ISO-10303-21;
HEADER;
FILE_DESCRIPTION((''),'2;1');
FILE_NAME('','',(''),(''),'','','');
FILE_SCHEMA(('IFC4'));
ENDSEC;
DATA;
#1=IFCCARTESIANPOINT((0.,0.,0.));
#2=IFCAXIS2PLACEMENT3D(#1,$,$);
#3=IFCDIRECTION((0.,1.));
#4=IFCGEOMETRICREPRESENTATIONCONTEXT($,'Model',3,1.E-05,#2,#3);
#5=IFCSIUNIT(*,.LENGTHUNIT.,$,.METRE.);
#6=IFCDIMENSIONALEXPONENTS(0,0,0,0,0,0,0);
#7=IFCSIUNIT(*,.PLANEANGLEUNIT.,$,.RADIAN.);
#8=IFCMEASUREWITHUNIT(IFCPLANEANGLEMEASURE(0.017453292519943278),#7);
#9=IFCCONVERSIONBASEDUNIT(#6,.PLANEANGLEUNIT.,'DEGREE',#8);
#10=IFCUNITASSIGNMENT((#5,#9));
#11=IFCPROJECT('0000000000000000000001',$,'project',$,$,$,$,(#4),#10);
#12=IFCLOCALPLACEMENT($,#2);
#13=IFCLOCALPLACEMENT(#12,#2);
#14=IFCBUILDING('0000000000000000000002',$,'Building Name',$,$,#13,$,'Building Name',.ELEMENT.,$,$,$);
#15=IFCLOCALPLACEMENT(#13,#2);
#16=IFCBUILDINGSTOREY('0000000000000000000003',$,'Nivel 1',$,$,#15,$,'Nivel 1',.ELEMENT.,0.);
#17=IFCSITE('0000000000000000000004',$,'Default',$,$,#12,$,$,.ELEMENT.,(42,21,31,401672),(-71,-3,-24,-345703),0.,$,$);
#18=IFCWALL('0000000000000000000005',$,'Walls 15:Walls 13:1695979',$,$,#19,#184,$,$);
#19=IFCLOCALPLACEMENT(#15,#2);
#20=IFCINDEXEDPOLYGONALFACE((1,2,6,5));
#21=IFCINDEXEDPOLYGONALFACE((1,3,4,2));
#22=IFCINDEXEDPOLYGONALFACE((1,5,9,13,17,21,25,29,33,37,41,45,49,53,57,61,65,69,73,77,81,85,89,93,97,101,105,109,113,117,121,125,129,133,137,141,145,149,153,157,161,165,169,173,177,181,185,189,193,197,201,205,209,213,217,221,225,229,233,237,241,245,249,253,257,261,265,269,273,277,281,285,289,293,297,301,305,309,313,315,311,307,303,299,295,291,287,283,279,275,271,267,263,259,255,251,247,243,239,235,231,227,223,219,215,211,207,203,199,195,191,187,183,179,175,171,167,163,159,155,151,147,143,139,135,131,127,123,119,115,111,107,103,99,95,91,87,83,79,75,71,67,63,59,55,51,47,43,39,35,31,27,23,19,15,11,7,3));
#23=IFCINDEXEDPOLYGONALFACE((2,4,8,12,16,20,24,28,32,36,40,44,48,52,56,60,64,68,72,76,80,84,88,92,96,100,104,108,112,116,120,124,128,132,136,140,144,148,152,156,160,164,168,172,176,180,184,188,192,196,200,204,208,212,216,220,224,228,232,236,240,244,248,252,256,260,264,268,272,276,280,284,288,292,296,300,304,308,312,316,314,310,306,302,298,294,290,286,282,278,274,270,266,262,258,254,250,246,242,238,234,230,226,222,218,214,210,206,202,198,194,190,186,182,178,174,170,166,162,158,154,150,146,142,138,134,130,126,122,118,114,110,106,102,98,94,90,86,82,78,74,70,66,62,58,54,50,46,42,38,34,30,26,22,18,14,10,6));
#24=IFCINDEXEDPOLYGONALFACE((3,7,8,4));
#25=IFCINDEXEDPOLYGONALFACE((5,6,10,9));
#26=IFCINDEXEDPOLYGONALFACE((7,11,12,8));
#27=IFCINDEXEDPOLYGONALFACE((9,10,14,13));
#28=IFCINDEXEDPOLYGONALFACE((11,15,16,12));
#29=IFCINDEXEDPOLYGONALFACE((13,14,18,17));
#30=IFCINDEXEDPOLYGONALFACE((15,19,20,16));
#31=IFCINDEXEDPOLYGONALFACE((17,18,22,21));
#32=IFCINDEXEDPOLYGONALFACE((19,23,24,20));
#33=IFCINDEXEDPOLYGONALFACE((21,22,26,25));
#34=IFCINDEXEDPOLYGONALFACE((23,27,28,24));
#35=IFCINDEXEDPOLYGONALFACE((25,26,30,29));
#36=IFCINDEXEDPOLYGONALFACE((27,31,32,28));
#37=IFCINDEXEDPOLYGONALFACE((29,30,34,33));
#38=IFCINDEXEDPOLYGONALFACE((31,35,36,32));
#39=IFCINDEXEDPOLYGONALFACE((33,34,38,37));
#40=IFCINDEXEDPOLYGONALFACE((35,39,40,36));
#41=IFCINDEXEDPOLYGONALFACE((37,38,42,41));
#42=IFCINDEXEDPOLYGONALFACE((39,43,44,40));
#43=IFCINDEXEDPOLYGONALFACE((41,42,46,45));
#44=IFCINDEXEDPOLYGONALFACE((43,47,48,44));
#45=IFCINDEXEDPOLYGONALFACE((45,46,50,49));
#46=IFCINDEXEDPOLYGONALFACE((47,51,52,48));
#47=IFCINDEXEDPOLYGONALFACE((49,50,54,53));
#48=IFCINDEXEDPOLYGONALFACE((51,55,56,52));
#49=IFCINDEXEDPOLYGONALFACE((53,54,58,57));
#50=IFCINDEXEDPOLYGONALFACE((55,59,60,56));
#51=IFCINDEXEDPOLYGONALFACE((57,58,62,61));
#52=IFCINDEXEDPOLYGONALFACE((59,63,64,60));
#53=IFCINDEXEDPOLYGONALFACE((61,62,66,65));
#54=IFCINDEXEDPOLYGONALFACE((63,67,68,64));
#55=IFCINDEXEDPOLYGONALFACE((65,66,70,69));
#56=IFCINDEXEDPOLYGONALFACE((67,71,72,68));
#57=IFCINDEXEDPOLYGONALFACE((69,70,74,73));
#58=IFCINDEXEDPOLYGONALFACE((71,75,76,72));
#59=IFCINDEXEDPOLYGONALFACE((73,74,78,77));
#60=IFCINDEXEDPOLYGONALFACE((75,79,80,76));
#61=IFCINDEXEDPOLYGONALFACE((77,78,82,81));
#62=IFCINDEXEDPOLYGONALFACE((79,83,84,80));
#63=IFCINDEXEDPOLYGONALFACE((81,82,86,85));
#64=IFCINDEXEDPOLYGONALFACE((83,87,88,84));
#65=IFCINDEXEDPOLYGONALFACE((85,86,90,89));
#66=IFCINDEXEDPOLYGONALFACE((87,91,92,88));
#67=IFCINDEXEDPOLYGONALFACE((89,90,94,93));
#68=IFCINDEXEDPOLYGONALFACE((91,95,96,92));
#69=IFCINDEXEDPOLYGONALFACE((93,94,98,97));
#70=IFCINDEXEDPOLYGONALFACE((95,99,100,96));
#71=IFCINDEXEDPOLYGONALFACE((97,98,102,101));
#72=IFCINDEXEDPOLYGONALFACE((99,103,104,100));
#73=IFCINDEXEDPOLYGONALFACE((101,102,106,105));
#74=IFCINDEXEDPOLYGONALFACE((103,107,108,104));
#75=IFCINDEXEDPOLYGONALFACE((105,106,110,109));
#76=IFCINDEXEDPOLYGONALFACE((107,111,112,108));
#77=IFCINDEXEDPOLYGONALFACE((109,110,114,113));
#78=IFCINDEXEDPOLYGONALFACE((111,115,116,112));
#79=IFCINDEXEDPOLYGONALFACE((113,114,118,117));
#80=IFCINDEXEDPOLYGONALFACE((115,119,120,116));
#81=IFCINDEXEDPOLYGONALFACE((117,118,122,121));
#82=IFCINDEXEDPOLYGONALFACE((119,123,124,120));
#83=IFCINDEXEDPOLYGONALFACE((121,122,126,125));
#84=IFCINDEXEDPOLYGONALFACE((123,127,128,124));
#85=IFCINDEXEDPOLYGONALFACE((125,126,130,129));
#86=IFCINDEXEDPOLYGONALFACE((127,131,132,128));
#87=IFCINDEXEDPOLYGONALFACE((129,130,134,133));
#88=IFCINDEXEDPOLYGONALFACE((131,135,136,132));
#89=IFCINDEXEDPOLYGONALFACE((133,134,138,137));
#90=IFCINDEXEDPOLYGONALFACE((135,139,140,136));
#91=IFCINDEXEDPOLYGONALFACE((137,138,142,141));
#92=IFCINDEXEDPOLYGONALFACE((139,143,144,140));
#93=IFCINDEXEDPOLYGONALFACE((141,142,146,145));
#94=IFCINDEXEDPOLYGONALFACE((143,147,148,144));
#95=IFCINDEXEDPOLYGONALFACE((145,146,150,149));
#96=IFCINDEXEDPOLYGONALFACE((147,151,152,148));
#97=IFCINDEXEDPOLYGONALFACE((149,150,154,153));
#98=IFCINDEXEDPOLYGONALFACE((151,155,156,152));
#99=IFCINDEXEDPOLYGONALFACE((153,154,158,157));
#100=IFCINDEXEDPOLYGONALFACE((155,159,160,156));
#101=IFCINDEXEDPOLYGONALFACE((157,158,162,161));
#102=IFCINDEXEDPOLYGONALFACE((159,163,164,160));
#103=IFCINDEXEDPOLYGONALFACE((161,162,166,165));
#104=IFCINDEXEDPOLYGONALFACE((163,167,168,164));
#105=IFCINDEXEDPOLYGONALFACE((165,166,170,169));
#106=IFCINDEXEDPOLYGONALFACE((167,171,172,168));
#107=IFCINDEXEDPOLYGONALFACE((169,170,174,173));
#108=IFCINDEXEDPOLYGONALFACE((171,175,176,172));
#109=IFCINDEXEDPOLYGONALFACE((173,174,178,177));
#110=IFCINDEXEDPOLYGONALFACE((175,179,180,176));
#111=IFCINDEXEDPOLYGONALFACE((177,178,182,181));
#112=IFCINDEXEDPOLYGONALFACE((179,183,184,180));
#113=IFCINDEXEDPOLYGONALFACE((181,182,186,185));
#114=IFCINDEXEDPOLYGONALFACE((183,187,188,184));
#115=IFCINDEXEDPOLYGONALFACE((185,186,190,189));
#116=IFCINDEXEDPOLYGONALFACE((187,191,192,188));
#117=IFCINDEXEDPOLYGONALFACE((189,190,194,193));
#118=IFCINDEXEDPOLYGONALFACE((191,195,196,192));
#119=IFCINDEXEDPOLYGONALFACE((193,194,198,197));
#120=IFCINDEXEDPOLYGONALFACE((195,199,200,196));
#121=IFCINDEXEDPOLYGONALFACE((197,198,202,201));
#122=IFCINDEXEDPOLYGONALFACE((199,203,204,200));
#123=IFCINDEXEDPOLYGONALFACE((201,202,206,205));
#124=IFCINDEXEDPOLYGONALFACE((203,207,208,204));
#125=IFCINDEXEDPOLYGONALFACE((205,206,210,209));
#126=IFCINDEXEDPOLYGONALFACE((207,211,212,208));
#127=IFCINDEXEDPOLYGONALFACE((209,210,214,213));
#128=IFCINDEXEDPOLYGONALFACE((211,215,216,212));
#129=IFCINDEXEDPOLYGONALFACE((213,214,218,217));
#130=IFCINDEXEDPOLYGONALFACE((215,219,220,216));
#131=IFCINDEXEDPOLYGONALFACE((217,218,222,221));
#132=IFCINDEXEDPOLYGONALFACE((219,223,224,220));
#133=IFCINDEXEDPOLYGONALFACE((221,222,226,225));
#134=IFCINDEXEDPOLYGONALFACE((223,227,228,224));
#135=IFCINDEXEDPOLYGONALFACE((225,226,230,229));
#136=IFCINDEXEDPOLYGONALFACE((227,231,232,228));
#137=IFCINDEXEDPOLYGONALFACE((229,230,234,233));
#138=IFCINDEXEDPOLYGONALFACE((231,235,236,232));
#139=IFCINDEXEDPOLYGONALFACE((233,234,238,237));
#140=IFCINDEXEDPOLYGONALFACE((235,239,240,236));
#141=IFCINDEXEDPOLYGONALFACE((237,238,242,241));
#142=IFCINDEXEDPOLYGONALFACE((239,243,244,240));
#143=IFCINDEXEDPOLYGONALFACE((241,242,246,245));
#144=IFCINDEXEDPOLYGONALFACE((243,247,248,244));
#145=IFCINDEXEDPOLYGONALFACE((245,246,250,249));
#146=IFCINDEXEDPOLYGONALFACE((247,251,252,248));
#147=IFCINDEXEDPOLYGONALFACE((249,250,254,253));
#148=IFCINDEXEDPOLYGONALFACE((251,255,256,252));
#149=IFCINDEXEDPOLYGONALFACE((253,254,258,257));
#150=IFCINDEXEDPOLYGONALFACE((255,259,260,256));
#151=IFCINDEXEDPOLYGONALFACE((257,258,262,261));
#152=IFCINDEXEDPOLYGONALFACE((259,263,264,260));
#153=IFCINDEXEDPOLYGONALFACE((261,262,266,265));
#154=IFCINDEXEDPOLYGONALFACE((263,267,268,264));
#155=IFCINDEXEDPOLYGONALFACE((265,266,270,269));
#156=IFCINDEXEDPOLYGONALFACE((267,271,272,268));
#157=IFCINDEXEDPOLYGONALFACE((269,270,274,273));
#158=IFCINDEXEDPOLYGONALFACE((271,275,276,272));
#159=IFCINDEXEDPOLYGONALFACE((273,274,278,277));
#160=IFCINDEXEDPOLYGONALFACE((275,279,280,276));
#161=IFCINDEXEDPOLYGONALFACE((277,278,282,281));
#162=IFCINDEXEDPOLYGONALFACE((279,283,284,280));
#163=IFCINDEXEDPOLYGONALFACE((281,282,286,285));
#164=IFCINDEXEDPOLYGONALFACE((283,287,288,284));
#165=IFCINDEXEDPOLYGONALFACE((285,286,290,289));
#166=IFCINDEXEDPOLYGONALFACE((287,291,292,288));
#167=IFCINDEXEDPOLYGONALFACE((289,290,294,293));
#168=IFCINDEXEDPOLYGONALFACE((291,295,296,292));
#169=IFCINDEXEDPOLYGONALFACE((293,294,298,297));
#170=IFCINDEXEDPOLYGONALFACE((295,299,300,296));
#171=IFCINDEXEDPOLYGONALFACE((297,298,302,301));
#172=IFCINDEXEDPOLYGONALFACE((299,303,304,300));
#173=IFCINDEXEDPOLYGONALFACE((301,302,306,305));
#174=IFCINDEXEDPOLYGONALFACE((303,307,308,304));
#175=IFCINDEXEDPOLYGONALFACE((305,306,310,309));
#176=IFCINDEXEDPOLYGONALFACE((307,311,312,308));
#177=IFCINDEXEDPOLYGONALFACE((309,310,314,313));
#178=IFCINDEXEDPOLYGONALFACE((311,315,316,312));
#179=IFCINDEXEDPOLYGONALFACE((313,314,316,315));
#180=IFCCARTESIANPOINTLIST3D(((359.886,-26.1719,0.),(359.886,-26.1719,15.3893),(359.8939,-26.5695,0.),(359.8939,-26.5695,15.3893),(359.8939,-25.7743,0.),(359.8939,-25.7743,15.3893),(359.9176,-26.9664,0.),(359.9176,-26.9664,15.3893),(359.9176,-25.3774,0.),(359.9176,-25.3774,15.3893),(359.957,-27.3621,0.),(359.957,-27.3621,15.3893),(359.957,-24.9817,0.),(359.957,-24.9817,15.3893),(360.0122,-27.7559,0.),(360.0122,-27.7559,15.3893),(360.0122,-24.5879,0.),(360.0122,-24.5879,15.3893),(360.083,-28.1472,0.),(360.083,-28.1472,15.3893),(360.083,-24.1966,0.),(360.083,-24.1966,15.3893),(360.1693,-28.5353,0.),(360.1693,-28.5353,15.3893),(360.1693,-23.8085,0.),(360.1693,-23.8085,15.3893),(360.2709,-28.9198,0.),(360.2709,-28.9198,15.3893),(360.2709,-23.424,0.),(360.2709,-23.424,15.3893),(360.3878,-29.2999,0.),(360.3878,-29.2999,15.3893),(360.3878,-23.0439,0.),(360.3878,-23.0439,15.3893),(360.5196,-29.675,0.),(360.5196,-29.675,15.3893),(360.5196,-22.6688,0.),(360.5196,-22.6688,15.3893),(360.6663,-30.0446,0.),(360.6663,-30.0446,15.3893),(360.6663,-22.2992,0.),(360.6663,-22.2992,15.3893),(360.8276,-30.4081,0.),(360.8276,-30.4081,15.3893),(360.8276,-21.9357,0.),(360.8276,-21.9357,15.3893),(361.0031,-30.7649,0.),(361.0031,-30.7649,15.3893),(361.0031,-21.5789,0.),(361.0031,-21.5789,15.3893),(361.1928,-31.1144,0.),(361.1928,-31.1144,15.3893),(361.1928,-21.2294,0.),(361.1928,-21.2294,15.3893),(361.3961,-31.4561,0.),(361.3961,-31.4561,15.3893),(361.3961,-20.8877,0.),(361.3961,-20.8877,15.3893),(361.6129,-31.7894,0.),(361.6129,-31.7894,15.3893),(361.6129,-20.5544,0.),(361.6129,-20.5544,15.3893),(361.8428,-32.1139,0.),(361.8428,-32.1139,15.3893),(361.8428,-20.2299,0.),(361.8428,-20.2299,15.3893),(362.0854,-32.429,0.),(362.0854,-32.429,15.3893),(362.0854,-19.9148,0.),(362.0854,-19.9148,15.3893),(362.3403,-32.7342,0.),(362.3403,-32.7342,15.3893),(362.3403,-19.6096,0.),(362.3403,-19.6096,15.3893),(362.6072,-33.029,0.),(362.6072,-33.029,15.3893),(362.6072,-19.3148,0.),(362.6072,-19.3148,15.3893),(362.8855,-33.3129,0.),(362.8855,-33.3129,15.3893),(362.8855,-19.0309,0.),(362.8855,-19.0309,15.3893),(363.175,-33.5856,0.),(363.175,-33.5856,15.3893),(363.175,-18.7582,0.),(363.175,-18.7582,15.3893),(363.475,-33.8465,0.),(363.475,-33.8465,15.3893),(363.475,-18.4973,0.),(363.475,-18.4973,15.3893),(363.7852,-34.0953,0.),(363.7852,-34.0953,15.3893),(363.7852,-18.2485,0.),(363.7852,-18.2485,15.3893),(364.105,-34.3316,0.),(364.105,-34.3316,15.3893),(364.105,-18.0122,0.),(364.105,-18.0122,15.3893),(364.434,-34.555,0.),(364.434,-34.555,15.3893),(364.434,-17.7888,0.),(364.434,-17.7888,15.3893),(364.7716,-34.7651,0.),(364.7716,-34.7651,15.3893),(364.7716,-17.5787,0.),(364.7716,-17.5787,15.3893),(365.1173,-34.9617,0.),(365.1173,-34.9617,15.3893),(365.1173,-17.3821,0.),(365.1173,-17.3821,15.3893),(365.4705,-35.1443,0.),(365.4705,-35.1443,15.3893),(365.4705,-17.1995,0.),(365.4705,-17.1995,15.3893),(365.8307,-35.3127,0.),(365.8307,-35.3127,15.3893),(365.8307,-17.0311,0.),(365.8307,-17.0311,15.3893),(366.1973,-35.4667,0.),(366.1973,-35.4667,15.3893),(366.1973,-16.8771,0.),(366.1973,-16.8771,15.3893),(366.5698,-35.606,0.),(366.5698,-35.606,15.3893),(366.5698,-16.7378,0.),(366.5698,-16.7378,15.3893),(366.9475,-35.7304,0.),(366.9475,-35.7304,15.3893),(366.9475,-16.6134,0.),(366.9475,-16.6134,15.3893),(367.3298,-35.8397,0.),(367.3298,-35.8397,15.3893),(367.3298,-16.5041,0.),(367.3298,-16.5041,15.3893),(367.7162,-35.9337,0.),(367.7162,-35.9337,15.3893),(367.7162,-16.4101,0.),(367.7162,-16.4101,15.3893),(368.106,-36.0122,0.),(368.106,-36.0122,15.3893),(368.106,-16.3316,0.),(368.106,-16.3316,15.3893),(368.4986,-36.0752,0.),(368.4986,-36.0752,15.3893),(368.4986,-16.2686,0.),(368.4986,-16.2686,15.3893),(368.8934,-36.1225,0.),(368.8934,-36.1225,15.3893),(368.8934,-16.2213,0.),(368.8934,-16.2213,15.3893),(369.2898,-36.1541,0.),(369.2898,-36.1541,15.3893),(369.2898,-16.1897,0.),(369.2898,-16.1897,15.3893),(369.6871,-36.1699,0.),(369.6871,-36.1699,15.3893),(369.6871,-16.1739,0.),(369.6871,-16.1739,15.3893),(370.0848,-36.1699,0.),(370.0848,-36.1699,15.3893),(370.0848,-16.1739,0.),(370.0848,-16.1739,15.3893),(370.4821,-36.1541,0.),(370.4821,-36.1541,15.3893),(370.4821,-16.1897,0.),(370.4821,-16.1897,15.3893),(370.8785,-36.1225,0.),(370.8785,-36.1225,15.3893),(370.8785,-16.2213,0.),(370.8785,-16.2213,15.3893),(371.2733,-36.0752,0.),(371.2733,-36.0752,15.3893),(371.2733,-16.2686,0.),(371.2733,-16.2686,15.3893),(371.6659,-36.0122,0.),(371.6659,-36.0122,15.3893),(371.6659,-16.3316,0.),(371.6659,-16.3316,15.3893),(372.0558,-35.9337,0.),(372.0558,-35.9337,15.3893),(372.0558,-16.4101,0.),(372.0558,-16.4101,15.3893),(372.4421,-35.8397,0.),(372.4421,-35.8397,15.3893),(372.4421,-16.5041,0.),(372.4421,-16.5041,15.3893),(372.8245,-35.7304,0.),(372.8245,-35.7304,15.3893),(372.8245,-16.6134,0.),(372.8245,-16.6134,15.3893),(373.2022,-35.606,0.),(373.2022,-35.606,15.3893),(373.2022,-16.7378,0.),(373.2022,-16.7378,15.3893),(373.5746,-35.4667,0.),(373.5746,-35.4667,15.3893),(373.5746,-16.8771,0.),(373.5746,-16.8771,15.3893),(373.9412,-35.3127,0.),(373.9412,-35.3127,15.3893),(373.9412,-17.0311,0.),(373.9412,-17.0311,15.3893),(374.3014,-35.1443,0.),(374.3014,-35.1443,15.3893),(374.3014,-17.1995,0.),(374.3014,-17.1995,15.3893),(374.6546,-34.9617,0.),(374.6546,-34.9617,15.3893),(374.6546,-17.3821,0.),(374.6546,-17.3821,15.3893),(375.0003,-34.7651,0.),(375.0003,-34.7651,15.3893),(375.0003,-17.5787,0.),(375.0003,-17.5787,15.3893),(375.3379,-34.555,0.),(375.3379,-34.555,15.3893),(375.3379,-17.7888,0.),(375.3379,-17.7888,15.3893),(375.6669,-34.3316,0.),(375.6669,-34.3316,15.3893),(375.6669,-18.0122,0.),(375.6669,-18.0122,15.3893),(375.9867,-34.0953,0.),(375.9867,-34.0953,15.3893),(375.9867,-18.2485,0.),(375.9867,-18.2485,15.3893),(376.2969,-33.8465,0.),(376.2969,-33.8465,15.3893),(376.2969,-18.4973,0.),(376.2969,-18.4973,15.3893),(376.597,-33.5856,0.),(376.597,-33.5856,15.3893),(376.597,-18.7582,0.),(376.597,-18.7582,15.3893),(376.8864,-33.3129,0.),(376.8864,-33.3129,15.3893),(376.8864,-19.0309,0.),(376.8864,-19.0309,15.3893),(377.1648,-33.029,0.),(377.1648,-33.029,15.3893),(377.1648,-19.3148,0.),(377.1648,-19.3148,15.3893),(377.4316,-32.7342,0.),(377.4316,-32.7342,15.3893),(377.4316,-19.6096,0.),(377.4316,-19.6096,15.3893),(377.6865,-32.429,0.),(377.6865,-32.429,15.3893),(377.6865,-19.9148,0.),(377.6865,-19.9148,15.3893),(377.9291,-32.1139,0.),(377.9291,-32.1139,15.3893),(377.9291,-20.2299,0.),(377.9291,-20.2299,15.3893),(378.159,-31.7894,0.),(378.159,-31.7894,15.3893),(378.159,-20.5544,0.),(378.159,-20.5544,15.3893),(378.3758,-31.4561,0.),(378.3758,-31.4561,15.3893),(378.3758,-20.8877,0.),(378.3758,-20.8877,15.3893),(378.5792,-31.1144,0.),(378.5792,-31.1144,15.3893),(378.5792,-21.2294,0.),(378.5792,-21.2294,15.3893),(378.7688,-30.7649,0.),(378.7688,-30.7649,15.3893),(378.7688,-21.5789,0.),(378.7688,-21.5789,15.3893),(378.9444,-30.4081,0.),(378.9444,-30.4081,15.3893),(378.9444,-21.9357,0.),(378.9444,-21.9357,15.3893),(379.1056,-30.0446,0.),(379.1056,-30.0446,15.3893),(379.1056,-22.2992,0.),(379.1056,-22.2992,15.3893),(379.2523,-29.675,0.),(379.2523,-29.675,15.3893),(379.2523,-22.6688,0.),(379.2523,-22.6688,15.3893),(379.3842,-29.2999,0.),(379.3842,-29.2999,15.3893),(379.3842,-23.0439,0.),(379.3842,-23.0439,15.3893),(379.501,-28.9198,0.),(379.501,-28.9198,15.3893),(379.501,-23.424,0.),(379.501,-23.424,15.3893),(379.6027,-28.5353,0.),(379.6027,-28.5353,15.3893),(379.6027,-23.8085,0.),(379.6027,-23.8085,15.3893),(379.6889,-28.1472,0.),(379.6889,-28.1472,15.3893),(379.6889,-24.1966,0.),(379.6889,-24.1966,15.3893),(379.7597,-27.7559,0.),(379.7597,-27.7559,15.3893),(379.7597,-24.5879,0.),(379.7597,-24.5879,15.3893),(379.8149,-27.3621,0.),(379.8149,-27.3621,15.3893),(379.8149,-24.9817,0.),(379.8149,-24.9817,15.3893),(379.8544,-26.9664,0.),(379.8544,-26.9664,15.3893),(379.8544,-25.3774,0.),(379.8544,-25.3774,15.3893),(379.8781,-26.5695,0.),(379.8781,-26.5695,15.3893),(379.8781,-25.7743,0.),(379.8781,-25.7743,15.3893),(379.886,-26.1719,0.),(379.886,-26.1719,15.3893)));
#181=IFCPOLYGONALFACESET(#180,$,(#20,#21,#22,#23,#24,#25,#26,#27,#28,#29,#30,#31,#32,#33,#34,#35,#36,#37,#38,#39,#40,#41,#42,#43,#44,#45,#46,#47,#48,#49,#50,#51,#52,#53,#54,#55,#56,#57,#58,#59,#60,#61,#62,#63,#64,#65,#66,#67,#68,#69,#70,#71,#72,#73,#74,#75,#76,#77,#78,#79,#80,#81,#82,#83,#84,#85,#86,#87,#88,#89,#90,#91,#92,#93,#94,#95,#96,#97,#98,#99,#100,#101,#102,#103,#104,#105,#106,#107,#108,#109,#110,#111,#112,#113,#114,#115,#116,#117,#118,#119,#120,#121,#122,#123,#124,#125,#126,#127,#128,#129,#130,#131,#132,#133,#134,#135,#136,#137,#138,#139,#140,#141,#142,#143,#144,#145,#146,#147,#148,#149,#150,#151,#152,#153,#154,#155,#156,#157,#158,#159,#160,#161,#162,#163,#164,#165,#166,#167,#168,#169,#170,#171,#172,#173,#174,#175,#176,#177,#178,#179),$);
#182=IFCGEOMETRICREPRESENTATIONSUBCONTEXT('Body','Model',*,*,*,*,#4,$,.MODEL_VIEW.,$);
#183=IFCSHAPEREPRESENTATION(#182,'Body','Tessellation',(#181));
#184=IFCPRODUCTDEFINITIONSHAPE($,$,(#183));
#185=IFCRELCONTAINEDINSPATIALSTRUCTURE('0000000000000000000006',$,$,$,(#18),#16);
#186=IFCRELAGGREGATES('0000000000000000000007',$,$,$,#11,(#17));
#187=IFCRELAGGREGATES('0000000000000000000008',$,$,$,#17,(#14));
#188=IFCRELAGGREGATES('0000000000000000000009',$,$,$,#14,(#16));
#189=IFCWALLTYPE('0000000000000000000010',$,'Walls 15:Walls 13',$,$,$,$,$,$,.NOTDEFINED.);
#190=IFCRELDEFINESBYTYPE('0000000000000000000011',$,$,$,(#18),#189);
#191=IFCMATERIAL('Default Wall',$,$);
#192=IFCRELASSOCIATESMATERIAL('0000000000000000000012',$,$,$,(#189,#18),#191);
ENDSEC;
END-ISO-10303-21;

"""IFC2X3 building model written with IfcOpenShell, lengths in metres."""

from ifc_helpers import new_model, entity, si_unit, converted_unit, direction, frame, frame_2d, origin, place, context, subcontext, project, spatial, circle, extrude, material, type_object, element, save


model = new_model("IFC2X3")

# Units and contexts
model_context = context("Model", 3, precision=1e-05, world=origin(), true_north=direction((0.0, 1.0)))
body_context = subcontext(model_context, "Body", "Model", "MODEL_VIEW")
ifc_project = project(units=[si_unit("LENGTHUNIT", "METRE"), converted_unit("PLANEANGLEUNIT", "DEGREE", entity("IfcPlaneAngleMeasure", 0.017453292519943278), si_unit("PLANEANGLEUNIT", "RADIAN"), dimensions=[0, 0, 0, 0, 0, 0, 0])], contexts=[model_context])

# Site, building, storey
site_placement = place(None, origin())
site = spatial("IfcSite", under=ifc_project, at=site_placement, Name="Default", CompositionType="ELEMENT", RefLatitude=(42, 21, 31, 401672), RefLongitude=(-71, -3, -24, -345703), RefElevation=0.0)
building_placement = place(site_placement, origin())
building = spatial("IfcBuilding", under=site, at=building_placement, Name="Building Name", LongName="Building Name", CompositionType="ELEMENT")
storey_placement = place(building_placement, origin())
storey = spatial("IfcBuildingStorey", under=building, at=storey_placement, Name="Nivel 1", LongName="Nivel 1", CompositionType="ELEMENT", Elevation=0.0)

# Wall
ifc_material_1 = material(Name="Default Wall")
wall_type_1 = type_object("IfcWallType", Name="Walls 15:Walls 13", PredefinedType="NOTDEFINED", material=ifc_material_1)
wall_1_placement = place(storey_placement, frame((359.886, -36.1719, 0.0)))
element("IfcWall", 1, at=wall_1_placement, inside=storey, type_object=wall_type_1, material=ifc_material_1, Name="Walls 15:Walls 13:1695979", context=body_context, shape_type="SweptSolid", body=[
    extrude(circle(Radius=10.0, at=frame_2d((0.0, 0.0), x_axis=(1.0, 0.0))), frame((10.0, 10.0, 0.0)), (0.0, 0.0, 1.0), 15.3893),
])

save(model, "model.ifc")
